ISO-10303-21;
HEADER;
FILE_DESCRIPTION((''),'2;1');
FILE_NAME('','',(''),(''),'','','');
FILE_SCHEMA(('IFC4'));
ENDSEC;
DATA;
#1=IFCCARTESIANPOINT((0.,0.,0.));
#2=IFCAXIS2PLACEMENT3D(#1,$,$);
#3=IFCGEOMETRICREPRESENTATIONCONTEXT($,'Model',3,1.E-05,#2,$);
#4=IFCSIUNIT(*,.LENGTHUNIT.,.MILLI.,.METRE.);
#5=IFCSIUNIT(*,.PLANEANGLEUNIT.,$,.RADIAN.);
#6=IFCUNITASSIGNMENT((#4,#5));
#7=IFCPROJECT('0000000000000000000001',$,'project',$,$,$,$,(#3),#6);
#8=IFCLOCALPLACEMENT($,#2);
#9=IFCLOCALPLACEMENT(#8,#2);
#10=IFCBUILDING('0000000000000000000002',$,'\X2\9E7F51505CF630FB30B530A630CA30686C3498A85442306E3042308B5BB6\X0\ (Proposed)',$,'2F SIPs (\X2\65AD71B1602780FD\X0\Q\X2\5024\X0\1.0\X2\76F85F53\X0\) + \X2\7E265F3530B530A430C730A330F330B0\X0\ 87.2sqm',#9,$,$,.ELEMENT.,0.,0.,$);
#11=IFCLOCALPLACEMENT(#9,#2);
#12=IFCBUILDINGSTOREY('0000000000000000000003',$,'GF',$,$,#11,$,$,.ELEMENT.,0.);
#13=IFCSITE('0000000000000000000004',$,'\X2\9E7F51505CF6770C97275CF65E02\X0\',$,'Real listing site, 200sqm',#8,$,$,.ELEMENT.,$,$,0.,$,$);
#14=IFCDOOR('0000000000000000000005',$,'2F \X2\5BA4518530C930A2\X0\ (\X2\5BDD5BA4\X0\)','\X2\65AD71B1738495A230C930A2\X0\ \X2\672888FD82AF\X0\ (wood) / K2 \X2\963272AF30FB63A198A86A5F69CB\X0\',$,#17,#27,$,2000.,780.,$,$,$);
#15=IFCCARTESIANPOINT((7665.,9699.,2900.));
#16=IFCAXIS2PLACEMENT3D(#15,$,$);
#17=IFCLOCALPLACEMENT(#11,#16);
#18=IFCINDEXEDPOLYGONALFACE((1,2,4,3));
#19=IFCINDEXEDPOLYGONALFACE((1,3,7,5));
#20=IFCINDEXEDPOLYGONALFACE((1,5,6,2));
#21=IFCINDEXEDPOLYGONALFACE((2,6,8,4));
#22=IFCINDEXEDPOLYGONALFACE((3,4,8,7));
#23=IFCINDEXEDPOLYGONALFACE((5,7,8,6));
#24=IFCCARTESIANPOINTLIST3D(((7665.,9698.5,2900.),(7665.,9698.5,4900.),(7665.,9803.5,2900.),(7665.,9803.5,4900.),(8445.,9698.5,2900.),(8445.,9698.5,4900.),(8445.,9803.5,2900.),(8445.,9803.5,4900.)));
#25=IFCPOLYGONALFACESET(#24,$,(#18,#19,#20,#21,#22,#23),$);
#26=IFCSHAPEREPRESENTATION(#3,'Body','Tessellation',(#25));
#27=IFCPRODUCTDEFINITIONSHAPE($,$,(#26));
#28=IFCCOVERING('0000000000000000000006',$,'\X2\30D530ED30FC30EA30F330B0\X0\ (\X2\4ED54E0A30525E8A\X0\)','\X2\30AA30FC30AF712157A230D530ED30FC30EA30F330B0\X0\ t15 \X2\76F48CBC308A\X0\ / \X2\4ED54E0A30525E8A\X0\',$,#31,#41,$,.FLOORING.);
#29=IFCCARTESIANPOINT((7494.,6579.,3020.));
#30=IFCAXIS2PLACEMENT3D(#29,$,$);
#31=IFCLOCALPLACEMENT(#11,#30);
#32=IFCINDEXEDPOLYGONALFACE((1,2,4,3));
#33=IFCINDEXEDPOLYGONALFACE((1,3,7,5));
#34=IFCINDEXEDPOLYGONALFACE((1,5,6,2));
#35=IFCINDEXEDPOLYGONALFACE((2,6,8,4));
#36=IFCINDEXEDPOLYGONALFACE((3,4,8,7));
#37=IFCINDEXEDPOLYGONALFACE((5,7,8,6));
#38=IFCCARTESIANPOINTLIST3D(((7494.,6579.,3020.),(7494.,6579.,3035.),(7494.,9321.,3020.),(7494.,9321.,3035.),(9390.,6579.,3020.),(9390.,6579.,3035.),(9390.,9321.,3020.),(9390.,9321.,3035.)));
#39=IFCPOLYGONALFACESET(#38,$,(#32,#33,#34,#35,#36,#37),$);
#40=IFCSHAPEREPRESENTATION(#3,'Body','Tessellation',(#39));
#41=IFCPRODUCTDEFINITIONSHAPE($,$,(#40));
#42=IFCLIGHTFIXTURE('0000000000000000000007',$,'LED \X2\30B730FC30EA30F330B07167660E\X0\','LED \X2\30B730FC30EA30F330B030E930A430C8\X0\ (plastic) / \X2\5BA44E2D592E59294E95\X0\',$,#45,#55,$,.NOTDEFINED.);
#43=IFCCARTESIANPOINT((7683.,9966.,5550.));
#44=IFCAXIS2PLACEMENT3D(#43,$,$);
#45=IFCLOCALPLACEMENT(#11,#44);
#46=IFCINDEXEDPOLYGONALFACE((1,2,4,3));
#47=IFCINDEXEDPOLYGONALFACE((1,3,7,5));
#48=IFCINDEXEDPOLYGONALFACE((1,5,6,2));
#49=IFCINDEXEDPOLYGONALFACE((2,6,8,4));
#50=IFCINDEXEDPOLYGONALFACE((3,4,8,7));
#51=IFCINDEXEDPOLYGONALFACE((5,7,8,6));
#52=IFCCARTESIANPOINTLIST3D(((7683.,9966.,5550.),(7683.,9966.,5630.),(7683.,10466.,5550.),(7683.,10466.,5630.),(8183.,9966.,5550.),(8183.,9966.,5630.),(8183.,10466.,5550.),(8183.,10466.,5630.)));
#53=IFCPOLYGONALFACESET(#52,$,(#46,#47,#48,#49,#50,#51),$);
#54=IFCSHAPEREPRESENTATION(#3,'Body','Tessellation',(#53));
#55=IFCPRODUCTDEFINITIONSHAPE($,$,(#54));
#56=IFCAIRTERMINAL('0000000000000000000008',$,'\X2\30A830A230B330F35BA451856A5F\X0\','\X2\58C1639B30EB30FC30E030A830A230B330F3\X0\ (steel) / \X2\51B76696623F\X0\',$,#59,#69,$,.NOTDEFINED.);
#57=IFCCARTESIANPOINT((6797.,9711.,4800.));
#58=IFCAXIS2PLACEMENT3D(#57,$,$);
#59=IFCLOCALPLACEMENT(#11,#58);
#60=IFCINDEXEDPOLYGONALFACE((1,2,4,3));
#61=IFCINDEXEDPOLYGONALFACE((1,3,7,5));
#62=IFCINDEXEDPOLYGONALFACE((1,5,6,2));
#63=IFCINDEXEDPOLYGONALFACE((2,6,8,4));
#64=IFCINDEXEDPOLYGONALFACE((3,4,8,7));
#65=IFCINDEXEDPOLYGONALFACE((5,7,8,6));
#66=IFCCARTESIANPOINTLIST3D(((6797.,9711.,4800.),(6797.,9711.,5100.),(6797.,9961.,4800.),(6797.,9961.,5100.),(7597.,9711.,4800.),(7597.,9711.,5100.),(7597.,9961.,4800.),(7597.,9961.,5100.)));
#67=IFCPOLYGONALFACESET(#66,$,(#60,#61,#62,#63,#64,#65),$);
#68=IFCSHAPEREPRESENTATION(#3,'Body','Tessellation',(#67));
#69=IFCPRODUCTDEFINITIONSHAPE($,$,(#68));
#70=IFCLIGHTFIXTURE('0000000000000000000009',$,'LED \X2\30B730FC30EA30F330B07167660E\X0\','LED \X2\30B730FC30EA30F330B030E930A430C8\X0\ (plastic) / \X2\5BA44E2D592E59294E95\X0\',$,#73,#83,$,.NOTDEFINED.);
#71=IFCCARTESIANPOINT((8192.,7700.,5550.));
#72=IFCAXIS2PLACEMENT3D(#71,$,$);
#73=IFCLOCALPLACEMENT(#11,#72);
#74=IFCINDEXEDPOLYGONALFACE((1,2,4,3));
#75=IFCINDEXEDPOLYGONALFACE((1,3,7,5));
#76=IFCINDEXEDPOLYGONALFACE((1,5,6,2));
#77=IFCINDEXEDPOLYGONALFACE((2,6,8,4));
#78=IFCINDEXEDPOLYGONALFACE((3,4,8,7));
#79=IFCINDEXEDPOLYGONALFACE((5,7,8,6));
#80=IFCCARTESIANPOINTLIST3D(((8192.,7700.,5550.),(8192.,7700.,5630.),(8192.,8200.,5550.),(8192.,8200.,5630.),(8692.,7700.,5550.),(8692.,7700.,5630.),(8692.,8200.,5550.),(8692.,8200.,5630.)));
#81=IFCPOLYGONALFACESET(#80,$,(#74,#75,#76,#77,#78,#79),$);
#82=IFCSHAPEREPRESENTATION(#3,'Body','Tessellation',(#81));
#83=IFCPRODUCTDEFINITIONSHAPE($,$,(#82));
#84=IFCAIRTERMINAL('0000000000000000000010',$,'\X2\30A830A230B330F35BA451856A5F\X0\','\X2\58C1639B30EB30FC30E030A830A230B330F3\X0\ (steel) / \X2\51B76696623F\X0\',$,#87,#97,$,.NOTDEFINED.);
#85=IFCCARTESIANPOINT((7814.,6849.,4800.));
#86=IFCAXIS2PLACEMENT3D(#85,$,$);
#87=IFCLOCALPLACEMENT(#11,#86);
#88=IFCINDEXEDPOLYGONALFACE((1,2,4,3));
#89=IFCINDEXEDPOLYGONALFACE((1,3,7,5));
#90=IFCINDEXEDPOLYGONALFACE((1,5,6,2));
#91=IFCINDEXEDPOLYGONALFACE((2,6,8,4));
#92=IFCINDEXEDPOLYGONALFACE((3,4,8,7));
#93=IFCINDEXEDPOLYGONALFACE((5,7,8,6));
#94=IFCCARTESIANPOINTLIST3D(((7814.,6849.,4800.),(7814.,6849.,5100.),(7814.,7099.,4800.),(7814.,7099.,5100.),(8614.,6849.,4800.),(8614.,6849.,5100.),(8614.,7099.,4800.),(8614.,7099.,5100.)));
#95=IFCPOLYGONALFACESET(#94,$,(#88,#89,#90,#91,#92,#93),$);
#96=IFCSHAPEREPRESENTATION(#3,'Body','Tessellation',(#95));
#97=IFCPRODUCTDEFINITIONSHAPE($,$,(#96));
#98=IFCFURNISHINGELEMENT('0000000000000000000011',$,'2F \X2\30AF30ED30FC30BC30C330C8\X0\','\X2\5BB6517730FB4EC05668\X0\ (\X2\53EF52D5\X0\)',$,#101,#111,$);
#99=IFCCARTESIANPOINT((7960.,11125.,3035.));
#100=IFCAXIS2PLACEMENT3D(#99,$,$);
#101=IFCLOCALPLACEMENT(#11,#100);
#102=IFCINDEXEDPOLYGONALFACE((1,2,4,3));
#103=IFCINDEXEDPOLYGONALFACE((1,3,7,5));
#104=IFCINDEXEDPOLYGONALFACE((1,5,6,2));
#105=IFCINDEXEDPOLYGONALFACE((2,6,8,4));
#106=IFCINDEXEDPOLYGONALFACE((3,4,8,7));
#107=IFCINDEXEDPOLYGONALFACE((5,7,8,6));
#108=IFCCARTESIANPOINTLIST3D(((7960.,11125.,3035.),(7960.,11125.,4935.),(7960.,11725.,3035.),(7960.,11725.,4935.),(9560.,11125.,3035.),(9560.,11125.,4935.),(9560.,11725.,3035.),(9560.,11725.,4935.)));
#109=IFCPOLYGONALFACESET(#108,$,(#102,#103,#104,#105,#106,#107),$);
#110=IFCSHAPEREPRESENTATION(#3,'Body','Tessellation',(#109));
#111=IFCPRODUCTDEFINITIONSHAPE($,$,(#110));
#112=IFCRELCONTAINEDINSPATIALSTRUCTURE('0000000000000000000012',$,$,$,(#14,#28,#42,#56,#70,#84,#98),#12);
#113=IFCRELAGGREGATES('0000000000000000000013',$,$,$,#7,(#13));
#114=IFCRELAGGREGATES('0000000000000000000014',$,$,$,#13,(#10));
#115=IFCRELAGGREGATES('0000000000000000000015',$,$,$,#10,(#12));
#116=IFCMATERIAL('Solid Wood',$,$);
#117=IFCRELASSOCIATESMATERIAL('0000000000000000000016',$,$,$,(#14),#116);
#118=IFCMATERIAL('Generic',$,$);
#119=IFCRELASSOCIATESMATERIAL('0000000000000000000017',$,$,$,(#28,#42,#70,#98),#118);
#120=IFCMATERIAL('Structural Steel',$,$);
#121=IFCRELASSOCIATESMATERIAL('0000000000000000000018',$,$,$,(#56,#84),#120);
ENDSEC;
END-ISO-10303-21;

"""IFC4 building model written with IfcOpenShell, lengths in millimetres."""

from ifc_helpers import new_model, si_unit, frame, frame_2d, origin, place, context, project, spatial, rectangle, extrude, material, element, save


model = new_model("IFC4")

# Units and contexts
model_context = context("Model", 3, precision=1e-05, world=origin())
ifc_project = project(units=[si_unit("LENGTHUNIT", "METRE", prefix="MILLI"), si_unit("PLANEANGLEUNIT", "RADIAN")], contexts=[model_context])

# Site, building, storey
site_placement = place(None, origin())
site = spatial("IfcSite", under=ifc_project, at=site_placement, Name="鹿児島県霧島市", ObjectType="Real listing site, 200sqm", CompositionType="ELEMENT", RefElevation=0.0)
building_placement = place(site_placement, origin())
building = spatial("IfcBuilding", under=site, at=building_placement, Name="鹿児島・サウナと水風呂のある家 (Proposed)", ObjectType="2F SIPs (断熱性能Q値1.0相当) + 縦張サイディング 87.2sqm", CompositionType="ELEMENT", ElevationOfRefHeight=0.0, ElevationOfTerrain=0.0)
storey_placement = place(building_placement, origin())
storey = spatial("IfcBuildingStorey", under=building, at=storey_placement, Name="GF", CompositionType="ELEMENT", Elevation=0.0)

# Shared definitions
ifc_material_1 = material(Name="Solid Wood")

# Door
door_placement = place(storey_placement, frame((7665.0, 9699.0, 2900.0)))
element("IfcDoor", 1, at=door_placement, inside=storey, material=ifc_material_1, Name="2F 室内ドア (寝室)", Description="断熱玄関ドア 木製芯 (wood) / K2 防犯・採風機構", OverallHeight=2000.0, OverallWidth=780.0, context=model_context, shape_type="SweptSolid", body=[
    extrude(rectangle(XDim=780.0, YDim=105.0, at=frame_2d((390.0, 52.0))), frame((7665.0, 9699.0, 2900.0)), (0.0, 0.0, 1.0), 2000.0),
])

# Covering
ifc_material_2 = material(Name="Generic")
covering_placement = place(storey_placement, frame((7494.0, 6579.0, 3020.0)))
element("IfcCovering", 2, at=covering_placement, inside=storey, material=ifc_material_2, Name="フローリング (仕上げ床)", Description="オーク無垢フローリング t15 直貼り / 仕上げ床", PredefinedType="FLOORING", context=model_context, shape_type="SweptSolid", body=[
    extrude(rectangle(XDim=1896.0, YDim=2742.0, at=frame_2d((948.0, 1371.0))), frame((7494.0, 6579.0, 3020.0)), (0.0, 0.0, 1.0), 15.0),
])

# Light fixture
light_fixture_1_placement = place(storey_placement, frame((7683.0, 9966.0, 5550.0)))
element("IfcLightFixture", 3, at=light_fixture_1_placement, inside=storey, material=ifc_material_2, Name="LED シーリング照明", Description="LED シーリングライト (plastic) / 室中央天井", PredefinedType="NOTDEFINED", context=model_context, shape_type="SweptSolid", body=[
    extrude(rectangle(XDim=500.0, YDim=500.0, at=frame_2d((250.0, 250.0))), frame((7683.0, 9966.0, 5550.0)), (0.0, 0.0, 1.0), 80.0),
])

# Air terminal
ifc_material_3 = material(Name="Structural Steel")
air_terminal_1_placement = place(storey_placement, frame((6797.0, 9711.0, 4800.0)))
element("IfcAirTerminal", 4, at=air_terminal_1_placement, inside=storey, material=ifc_material_3, Name="エアコン室内機", Description="壁掛ルームエアコン (steel) / 冷暖房", PredefinedType="NOTDEFINED", context=model_context, shape_type="SweptSolid", body=[
    extrude(rectangle(XDim=800.0, YDim=250.0, at=frame_2d((400.0, 125.0))), frame((6797.0, 9711.0, 4800.0)), (0.0, 0.0, 1.0), 300.0),
])

# Light fixture
light_fixture_2_placement = place(storey_placement, frame((8192.0, 7700.0, 5550.0)))
element("IfcLightFixture", 5, at=light_fixture_2_placement, inside=storey, material=ifc_material_2, Name="LED シーリング照明", Description="LED シーリングライト (plastic) / 室中央天井", PredefinedType="NOTDEFINED", context=model_context, shape_type="SweptSolid", body=[
    extrude(rectangle(XDim=500.0, YDim=500.0, at=frame_2d((250.0, 250.0))), frame((8192.0, 7700.0, 5550.0)), (0.0, 0.0, 1.0), 80.0),
])

# Air terminal
air_terminal_2_placement = place(storey_placement, frame((7814.0, 6849.0, 4800.0)))
element("IfcAirTerminal", 6, at=air_terminal_2_placement, inside=storey, material=ifc_material_3, Name="エアコン室内機", Description="壁掛ルームエアコン (steel) / 冷暖房", PredefinedType="NOTDEFINED", context=model_context, shape_type="SweptSolid", body=[
    extrude(rectangle(XDim=800.0, YDim=250.0, at=frame_2d((400.0, 125.0))), frame((7814.0, 6849.0, 4800.0)), (0.0, 0.0, 1.0), 300.0),
])

# Furnishing element
furnishing_placement = place(storey_placement, frame((7960.0, 11125.0, 3035.0)))
element("IfcFurnishingElement", 7, at=furnishing_placement, inside=storey, material=ifc_material_2, Name="2F クローゼット", Description="家具・什器 (可動)", context=model_context, shape_type="SweptSolid", body=[
    extrude(rectangle(XDim=1600.0, YDim=600.0, at=frame_2d((800.0, 300.0))), frame((7960.0, 11125.0, 3035.0)), (0.0, 0.0, 1.0), 1900.0),
])

save(model, "model.ifc")
